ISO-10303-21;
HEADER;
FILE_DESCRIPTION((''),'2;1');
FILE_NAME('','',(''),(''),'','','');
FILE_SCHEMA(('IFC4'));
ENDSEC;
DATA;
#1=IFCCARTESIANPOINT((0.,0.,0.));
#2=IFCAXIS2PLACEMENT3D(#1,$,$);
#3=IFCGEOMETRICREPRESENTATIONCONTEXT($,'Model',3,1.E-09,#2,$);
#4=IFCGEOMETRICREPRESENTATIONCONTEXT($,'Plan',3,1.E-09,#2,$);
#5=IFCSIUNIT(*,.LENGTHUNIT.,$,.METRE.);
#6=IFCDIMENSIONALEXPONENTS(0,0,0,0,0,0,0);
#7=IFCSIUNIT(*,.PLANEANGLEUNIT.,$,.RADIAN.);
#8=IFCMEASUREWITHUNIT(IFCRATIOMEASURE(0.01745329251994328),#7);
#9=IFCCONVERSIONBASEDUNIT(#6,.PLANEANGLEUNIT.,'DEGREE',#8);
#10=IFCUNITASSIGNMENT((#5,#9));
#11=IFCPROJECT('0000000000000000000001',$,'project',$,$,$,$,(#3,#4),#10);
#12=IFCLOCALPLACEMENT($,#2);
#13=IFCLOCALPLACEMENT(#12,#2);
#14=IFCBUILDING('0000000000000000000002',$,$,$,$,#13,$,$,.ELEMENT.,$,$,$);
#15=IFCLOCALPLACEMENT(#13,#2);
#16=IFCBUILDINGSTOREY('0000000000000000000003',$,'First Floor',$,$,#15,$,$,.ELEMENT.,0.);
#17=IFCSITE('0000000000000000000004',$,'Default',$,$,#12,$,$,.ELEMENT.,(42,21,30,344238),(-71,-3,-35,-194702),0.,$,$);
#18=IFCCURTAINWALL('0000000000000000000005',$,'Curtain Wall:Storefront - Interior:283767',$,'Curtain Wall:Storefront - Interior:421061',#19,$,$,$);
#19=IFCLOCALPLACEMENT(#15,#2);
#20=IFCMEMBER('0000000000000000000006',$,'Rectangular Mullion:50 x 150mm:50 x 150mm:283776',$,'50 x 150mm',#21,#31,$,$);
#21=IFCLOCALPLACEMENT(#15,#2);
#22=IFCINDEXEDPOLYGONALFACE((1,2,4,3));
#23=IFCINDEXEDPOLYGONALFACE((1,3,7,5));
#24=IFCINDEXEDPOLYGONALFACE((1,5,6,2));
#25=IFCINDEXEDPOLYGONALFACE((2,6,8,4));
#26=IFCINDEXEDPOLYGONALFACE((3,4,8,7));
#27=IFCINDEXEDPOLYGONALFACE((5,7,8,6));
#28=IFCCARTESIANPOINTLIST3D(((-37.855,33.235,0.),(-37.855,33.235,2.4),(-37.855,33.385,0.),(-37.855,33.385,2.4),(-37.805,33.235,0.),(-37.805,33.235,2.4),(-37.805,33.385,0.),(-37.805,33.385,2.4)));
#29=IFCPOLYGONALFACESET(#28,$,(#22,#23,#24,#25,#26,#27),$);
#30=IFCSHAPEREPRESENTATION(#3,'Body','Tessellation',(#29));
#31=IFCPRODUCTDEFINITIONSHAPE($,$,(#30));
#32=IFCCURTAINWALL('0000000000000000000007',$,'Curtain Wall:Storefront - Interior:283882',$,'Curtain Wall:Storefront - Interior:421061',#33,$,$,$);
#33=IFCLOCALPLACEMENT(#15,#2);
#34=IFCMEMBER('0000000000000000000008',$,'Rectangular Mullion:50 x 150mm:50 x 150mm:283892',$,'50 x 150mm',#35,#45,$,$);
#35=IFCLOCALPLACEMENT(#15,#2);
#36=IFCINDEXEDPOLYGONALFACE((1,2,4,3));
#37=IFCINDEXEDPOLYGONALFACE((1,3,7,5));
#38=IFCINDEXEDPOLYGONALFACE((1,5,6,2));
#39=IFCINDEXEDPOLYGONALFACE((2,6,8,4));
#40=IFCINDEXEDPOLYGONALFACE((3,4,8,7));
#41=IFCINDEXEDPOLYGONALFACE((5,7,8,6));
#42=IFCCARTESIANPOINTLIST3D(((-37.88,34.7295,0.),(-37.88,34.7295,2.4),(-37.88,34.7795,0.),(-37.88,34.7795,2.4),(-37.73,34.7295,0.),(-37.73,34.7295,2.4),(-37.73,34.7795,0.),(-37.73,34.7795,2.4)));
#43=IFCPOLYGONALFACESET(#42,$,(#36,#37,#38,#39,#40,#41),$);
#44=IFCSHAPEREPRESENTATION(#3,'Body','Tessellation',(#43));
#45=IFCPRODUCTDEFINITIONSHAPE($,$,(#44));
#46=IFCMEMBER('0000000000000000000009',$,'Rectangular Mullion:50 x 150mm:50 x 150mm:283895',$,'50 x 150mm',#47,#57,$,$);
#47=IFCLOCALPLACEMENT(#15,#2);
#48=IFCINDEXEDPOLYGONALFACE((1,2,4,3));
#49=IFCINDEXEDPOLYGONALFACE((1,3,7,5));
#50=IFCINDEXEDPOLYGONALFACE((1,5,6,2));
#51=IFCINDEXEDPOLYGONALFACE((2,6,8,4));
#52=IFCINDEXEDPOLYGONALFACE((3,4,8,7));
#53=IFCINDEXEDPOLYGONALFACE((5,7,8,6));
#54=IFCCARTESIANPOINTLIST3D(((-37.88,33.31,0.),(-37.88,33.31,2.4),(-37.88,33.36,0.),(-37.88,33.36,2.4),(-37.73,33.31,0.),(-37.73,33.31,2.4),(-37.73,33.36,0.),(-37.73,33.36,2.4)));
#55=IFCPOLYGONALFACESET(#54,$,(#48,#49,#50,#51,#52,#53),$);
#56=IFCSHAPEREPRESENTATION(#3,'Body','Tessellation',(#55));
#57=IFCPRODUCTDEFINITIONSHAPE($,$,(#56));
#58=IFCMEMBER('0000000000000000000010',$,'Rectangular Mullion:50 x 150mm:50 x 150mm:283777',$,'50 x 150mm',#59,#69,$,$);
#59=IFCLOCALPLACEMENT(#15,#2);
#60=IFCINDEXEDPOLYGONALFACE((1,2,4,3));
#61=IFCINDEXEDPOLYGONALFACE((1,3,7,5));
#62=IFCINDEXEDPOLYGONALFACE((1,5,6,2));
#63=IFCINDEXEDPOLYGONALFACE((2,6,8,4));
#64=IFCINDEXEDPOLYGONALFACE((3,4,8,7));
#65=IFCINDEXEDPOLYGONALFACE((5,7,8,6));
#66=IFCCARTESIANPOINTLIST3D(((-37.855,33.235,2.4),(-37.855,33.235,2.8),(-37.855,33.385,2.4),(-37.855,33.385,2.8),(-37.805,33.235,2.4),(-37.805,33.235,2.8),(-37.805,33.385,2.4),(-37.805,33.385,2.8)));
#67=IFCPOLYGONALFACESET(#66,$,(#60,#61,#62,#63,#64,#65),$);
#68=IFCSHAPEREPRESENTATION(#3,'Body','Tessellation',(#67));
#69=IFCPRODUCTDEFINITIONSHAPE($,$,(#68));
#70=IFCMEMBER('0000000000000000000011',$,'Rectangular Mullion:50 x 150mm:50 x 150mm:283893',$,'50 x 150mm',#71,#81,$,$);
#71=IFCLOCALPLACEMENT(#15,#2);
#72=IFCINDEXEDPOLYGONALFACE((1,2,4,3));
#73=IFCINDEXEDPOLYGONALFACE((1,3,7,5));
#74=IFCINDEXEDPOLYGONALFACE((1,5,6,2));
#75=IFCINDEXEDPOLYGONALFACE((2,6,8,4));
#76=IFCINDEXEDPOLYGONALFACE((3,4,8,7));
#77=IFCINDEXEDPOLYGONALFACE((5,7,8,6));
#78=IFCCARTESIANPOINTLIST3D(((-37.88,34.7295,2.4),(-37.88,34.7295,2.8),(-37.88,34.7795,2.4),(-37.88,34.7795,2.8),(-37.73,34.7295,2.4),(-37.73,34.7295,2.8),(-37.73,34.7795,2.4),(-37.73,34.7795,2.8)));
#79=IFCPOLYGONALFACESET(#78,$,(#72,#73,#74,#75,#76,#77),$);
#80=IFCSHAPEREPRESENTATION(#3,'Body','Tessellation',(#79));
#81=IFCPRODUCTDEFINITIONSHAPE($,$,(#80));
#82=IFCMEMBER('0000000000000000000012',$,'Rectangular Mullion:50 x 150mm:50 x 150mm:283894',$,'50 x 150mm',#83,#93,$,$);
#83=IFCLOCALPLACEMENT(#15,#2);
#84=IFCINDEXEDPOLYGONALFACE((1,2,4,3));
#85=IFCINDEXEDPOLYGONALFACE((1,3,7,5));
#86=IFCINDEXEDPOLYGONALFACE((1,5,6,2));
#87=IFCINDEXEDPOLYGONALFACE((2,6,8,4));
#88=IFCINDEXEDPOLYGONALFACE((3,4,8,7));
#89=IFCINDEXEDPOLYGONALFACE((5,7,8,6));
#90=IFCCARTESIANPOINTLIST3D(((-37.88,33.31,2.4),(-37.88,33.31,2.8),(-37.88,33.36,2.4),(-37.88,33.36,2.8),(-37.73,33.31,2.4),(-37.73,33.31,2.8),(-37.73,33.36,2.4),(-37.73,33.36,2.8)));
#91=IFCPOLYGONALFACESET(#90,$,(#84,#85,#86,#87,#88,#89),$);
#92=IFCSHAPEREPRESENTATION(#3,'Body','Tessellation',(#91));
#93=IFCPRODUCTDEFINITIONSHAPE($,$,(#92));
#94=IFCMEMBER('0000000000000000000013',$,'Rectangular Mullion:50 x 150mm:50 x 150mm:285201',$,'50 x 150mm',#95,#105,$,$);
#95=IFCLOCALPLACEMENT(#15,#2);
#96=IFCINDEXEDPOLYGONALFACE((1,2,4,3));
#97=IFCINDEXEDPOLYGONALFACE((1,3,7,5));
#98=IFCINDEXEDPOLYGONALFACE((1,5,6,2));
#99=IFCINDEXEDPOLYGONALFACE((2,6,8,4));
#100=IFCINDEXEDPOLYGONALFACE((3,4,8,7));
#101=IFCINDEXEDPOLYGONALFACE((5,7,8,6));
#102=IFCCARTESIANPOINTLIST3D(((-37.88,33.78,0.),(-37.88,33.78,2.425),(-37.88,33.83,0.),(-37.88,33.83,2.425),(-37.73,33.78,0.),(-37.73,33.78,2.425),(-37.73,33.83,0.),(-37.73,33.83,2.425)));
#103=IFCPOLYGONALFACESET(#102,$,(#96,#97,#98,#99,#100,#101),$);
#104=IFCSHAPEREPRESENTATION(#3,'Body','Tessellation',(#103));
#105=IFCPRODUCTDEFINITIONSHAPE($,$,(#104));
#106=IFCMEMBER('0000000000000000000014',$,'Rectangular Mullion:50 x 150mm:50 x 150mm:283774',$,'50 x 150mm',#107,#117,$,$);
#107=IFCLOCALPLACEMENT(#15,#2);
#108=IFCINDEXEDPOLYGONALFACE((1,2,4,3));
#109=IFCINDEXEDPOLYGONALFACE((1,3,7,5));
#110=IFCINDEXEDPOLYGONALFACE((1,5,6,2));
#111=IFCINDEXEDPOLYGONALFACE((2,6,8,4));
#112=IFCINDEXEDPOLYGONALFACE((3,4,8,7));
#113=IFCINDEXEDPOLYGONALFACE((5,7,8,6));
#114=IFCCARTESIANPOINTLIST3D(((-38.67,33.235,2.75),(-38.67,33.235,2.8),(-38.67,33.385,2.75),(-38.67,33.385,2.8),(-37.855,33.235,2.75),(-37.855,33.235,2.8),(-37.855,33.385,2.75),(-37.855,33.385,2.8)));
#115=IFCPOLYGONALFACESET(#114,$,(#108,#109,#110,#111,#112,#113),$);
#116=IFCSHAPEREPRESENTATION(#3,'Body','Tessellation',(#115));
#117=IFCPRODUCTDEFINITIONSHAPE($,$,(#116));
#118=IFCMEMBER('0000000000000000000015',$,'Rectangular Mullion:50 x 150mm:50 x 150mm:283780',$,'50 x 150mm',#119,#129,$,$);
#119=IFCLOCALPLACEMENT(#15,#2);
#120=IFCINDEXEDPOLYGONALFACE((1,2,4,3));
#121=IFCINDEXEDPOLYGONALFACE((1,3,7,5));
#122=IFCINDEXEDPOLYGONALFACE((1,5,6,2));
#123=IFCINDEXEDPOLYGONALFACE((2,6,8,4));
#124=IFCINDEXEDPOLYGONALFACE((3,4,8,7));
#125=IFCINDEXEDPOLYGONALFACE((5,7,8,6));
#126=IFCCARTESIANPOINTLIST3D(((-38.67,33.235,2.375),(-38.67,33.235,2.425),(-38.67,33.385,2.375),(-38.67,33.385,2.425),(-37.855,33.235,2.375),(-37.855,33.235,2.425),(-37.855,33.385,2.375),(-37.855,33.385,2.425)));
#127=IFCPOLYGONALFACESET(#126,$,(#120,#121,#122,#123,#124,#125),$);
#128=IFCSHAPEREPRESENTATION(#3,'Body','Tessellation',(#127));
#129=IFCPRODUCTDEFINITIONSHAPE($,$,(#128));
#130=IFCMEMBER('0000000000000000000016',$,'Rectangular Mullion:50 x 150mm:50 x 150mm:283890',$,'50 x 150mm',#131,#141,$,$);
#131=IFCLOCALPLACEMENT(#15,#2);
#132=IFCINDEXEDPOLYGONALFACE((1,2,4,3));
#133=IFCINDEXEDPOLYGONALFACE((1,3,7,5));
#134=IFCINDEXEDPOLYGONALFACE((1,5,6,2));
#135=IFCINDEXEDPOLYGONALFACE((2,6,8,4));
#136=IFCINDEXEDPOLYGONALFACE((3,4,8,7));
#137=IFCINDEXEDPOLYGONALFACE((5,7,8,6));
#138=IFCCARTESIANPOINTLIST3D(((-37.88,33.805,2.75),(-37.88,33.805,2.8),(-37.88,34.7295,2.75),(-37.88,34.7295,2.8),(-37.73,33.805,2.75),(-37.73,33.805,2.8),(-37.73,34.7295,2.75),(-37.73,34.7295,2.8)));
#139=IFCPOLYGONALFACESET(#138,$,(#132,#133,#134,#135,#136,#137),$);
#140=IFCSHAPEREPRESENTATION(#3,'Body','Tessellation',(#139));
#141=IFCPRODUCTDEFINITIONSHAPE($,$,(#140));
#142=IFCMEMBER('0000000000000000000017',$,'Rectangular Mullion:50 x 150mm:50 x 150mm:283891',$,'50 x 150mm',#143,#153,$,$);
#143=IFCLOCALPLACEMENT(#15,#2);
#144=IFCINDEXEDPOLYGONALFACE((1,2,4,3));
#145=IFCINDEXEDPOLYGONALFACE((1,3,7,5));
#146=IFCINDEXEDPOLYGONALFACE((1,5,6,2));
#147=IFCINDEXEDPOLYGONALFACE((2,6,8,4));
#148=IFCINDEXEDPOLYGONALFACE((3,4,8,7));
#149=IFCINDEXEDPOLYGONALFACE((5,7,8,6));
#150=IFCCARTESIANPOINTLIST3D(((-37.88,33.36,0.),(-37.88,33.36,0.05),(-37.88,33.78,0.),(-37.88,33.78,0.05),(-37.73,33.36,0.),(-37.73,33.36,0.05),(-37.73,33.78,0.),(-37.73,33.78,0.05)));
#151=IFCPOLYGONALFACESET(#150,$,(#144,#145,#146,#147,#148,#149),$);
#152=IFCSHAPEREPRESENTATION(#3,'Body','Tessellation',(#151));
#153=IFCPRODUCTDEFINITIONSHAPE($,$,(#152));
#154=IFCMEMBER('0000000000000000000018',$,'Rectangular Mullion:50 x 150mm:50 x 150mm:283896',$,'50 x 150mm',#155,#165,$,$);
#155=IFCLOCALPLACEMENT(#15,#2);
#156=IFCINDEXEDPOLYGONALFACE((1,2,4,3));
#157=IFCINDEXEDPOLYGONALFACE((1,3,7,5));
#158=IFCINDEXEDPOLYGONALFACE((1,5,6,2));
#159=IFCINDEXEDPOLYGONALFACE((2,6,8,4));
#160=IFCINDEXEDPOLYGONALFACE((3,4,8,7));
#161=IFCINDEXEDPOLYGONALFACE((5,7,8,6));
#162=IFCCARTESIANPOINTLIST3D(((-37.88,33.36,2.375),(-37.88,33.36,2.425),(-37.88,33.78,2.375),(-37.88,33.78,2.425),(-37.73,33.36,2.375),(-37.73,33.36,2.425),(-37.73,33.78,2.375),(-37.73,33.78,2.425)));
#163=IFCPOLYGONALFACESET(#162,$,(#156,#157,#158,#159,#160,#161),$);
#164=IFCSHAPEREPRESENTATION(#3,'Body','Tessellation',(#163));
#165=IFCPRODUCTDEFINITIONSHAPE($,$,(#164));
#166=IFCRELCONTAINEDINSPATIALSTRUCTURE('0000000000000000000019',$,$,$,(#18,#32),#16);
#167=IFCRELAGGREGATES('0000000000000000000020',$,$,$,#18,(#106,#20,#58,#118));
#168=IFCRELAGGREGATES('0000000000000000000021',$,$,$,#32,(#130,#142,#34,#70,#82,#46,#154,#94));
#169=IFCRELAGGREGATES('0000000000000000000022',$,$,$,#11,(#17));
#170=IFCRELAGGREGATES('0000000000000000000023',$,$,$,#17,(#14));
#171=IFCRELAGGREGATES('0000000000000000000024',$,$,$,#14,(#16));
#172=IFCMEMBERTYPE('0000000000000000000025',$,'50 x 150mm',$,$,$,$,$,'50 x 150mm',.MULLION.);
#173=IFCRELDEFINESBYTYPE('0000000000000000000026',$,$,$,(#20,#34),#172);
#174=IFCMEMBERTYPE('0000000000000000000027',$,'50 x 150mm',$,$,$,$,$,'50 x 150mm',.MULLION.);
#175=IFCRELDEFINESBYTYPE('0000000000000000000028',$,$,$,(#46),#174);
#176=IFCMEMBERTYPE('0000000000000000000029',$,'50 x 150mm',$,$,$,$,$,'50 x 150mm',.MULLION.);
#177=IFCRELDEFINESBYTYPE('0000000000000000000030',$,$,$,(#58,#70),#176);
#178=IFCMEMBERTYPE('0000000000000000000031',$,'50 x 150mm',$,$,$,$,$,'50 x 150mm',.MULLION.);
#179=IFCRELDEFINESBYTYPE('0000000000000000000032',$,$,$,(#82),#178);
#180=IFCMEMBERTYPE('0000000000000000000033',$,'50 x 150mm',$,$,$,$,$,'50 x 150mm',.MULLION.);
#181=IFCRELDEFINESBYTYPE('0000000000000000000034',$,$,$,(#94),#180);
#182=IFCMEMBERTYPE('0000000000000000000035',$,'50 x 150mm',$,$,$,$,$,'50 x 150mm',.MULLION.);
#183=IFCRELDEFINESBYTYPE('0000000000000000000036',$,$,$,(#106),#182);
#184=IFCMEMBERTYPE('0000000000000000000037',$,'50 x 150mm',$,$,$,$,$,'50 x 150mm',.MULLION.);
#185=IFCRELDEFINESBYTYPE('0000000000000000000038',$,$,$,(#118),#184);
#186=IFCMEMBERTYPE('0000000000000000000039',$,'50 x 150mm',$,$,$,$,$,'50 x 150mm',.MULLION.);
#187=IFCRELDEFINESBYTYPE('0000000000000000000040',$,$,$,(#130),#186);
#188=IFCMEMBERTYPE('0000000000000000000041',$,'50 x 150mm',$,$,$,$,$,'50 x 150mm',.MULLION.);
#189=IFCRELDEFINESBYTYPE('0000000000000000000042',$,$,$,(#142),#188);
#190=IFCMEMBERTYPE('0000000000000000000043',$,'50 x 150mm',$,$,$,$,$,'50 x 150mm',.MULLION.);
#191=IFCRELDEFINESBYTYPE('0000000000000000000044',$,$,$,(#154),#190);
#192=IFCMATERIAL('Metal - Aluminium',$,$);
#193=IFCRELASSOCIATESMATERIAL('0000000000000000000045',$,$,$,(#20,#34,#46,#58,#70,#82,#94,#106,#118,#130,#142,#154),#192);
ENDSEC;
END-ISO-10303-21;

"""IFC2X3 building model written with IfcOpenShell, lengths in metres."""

from ifc_helpers import new_model, entity, si_unit, converted_unit, frame, origin, origin_2d_with_axis, place, context, project, spatial, rectangle, extrude, source, transform, mapped, material, type_object, type_shapes, element, aggregate, save


model = new_model("IFC2X3")

# Units and contexts
model_context = context("Model", 3, precision=1e-09, world=origin())
plan_context = context("Plan", 3, precision=1e-09, world=origin())
ifc_project = project(units=[si_unit("LENGTHUNIT", "METRE"), converted_unit("PLANEANGLEUNIT", "DEGREE", entity("IfcRatioMeasure", 0.01745329251994328), si_unit("PLANEANGLEUNIT", "RADIAN"), dimensions=[0, 0, 0, 0, 0, 0, 0])], contexts=[model_context, plan_context])

# Site, building, storey
site_placement = place(None, origin())
site = spatial("IfcSite", under=ifc_project, at=site_placement, Name="Default", CompositionType="ELEMENT", RefLatitude=(42, 21, 30, 344238), RefLongitude=(-71, -3, -35, -194702), RefElevation=0.0)
building_placement = place(site_placement, origin())
building = spatial("IfcBuilding", under=site, at=building_placement, CompositionType="ELEMENT")
storey_placement = place(building_placement, origin())
storey = spatial("IfcBuildingStorey", under=building, at=storey_placement, Name="First Floor", CompositionType="ELEMENT", Elevation=0.0)

# Curtain wall, member
curtain_wall_1_placement = place(storey_placement, origin())
curtain_wall_1 = element("IfcCurtainWall", 1, at=curtain_wall_1_placement, inside=storey, Name="Curtain Wall:Storefront - Interior:283767", ObjectType="Curtain Wall:Storefront - Interior:421061")
ifc_material_1 = material(Name="Metal - Aluminium")
member_type_1 = type_object("IfcMemberType", Name="50 x 150mm", ElementType="50 x 150mm", PredefinedType="MULLION")
shared_shape_1 = source(origin(), model_context, "Body", "SweptSolid", [
    extrude(rectangle(XDim=0.05, YDim=0.15, at=origin_2d_with_axis()), frame((-0.025, 0.0, -2.4), z_axis=(0.0, 0.0, 1.0), x_axis=(-1.0, 0.0, 0.0)), (0.0, 0.0, 1.0), 2.4),
])
type_shapes(member_type_1, [shared_shape_1])
member_1_placement = place(storey_placement, frame((-37.805, 33.31, 0.0), z_axis=(0.0, 0.0, -1.0), x_axis=(1.0, 0.0, 0.0)))
member_1 = element("IfcMember", 2, at=member_1_placement, type_object=member_type_1, material=ifc_material_1, Name="Rectangular Mullion:50 x 150mm:50 x 150mm:283776", ObjectType="50 x 150mm", context=model_context, shape_type="MappedRepresentation", body=[
    mapped(shared_shape_1, transform((0.0, 0.0, 0.0), scale=1.0)),
])

# Curtain wall, members
curtain_wall_2_placement = place(storey_placement, origin())
curtain_wall_2 = element("IfcCurtainWall", 3, at=curtain_wall_2_placement, inside=storey, Name="Curtain Wall:Storefront - Interior:283882", ObjectType="Curtain Wall:Storefront - Interior:421061")
member_2_placement = place(storey_placement, frame((-37.805, 34.7795, 0.0), z_axis=(0.0, 0.0, -1.0), x_axis=(0.0, 1.0, 0.0)))
member_2 = element("IfcMember", 4, at=member_2_placement, type_object=member_type_1, material=ifc_material_1, Name="Rectangular Mullion:50 x 150mm:50 x 150mm:283892", ObjectType="50 x 150mm", context=model_context, shape_type="MappedRepresentation", body=[
    mapped(shared_shape_1, transform((0.0, 0.0, 0.0), scale=1.0)),
])
member_type_2 = type_object("IfcMemberType", Name="50 x 150mm", ElementType="50 x 150mm", PredefinedType="MULLION")
shared_shape_2 = source(origin(), model_context, "Body", "SweptSolid", [
    extrude(rectangle(XDim=0.05, YDim=0.15, at=origin_2d_with_axis()), frame((-0.025, 0.0, -2.4), z_axis=(0.0, 0.0, 1.0), x_axis=(-1.0, 0.0, 0.0)), (0.0, 0.0, 1.0), 2.4),
])
type_shapes(member_type_2, [shared_shape_2])
member_3_placement = place(storey_placement, frame((-37.805, 33.31, 2.4), z_axis=(0.0, 0.0, 1.0), x_axis=(0.0, -1.0, 0.0)))
member_3 = element("IfcMember", 5, at=member_3_placement, type_object=member_type_2, material=ifc_material_1, Name="Rectangular Mullion:50 x 150mm:50 x 150mm:283895", ObjectType="50 x 150mm", context=model_context, shape_type="MappedRepresentation", body=[
    mapped(shared_shape_2, transform((0.0, 0.0, 0.0), scale=1.0)),
])

# Members
member_type_3 = type_object("IfcMemberType", Name="50 x 150mm", ElementType="50 x 150mm", PredefinedType="MULLION")
shared_shape_3 = source(origin(), model_context, "Body", "SweptSolid", [
    extrude(rectangle(XDim=0.05, YDim=0.15, at=origin_2d_with_axis()), frame((-0.025, 0.0, -0.4), z_axis=(0.0, 0.0, 1.0), x_axis=(-1.0, 0.0, 0.0)), (0.0, 0.0, 1.0), 0.4),
])
type_shapes(member_type_3, [shared_shape_3])
member_4_placement = place(storey_placement, frame((-37.805, 33.31, 2.4), z_axis=(0.0, 0.0, -1.0), x_axis=(1.0, 0.0, 0.0)))
member_4 = element("IfcMember", 6, at=member_4_placement, type_object=member_type_3, material=ifc_material_1, Name="Rectangular Mullion:50 x 150mm:50 x 150mm:283777", ObjectType="50 x 150mm", context=model_context, shape_type="MappedRepresentation", body=[
    mapped(shared_shape_3, transform((0.0, 0.0, 0.0), scale=1.0)),
])
member_5_placement = place(storey_placement, frame((-37.805, 34.7795, 2.4), z_axis=(0.0, 0.0, -1.0), x_axis=(0.0, 1.0, 0.0)))
member_5 = element("IfcMember", 7, at=member_5_placement, type_object=member_type_3, material=ifc_material_1, Name="Rectangular Mullion:50 x 150mm:50 x 150mm:283893", ObjectType="50 x 150mm", context=model_context, shape_type="MappedRepresentation", body=[
    mapped(shared_shape_3, transform((0.0, 0.0, 0.0), scale=1.0)),
])
member_type_4 = type_object("IfcMemberType", Name="50 x 150mm", ElementType="50 x 150mm", PredefinedType="MULLION")
shared_shape_4 = source(origin(), model_context, "Body", "SweptSolid", [
    extrude(rectangle(XDim=0.05, YDim=0.15, at=origin_2d_with_axis()), frame((-0.025, 0.0, -0.4), z_axis=(0.0, 0.0, 1.0), x_axis=(-1.0, 0.0, 0.0)), (0.0, 0.0, 1.0), 0.4),
])
type_shapes(member_type_4, [shared_shape_4])
member_6_placement = place(storey_placement, frame((-37.805, 33.31, 2.8), z_axis=(0.0, 0.0, 1.0), x_axis=(0.0, -1.0, 0.0)))
member_6 = element("IfcMember", 8, at=member_6_placement, type_object=member_type_4, material=ifc_material_1, Name="Rectangular Mullion:50 x 150mm:50 x 150mm:283894", ObjectType="50 x 150mm", context=model_context, shape_type="MappedRepresentation", body=[
    mapped(shared_shape_4, transform((0.0, 0.0, 0.0), scale=1.0)),
])
member_type_5 = type_object("IfcMemberType", Name="50 x 150mm", ElementType="50 x 150mm", PredefinedType="MULLION")
shared_shape_5 = source(origin(), model_context, "Body", "SweptSolid", [
    extrude(rectangle(XDim=0.05, YDim=0.15, at=origin_2d_with_axis()), frame((0.0, 0.0, -2.425), z_axis=(0.0, 0.0, 1.0), x_axis=(-1.0, 0.0, 0.0)), (0.0, 0.0, 1.0), 2.425),
])
type_shapes(member_type_5, [shared_shape_5])
member_7_placement = place(storey_placement, frame((-37.805, 33.805, 0.0), z_axis=(0.0, 0.0, -1.0), x_axis=(0.0, 1.0, 0.0)))
member_7 = element("IfcMember", 9, at=member_7_placement, type_object=member_type_5, material=ifc_material_1, Name="Rectangular Mullion:50 x 150mm:50 x 150mm:285201", ObjectType="50 x 150mm", context=model_context, shape_type="MappedRepresentation", body=[
    mapped(shared_shape_5, transform((0.0, 0.0, 0.0), scale=1.0)),
])
member_type_6 = type_object("IfcMemberType", Name="50 x 150mm", ElementType="50 x 150mm", PredefinedType="MULLION")
shared_shape_6 = source(origin(), model_context, "Body", "SweptSolid", [
    extrude(rectangle(XDim=0.05, YDim=0.15, at=origin_2d_with_axis()), frame((-0.025, 0.0, -0.815), z_axis=(0.0, 0.0, 1.0), x_axis=(-1.0, 0.0, 0.0)), (0.0, 0.0, 1.0), 0.815),
])
type_shapes(member_type_6, [shared_shape_6])
member_8_placement = place(storey_placement, frame((-37.855, 33.31, 2.8), z_axis=(1.0, 0.0, 0.0), x_axis=(0.0, 0.0, 1.0)))
member_8 = element("IfcMember", 10, at=member_8_placement, type_object=member_type_6, material=ifc_material_1, Name="Rectangular Mullion:50 x 150mm:50 x 150mm:283774", ObjectType="50 x 150mm", context=model_context, shape_type="MappedRepresentation", body=[
    mapped(shared_shape_6, transform((0.0, 0.0, 0.0), scale=1.0)),
])
member_type_7 = type_object("IfcMemberType", Name="50 x 150mm", ElementType="50 x 150mm", PredefinedType="MULLION")
shared_shape_7 = source(origin(), model_context, "Body", "SweptSolid", [
    extrude(rectangle(XDim=0.05, YDim=0.15, at=origin_2d_with_axis()), frame((0.0, 0.0, -0.815), z_axis=(0.0, 0.0, 1.0), x_axis=(-1.0, 0.0, 0.0)), (0.0, 0.0, 1.0), 0.815),
])
type_shapes(member_type_7, [shared_shape_7])
member_9_placement = place(storey_placement, frame((-37.855, 33.31, 2.4), z_axis=(1.0, 0.0, 0.0), x_axis=(0.0, 0.0, 1.0)))
member_9 = element("IfcMember", 11, at=member_9_placement, type_object=member_type_7, material=ifc_material_1, Name="Rectangular Mullion:50 x 150mm:50 x 150mm:283780", ObjectType="50 x 150mm", context=model_context, shape_type="MappedRepresentation", body=[
    mapped(shared_shape_7, transform((0.0, 0.0, 0.0), scale=1.0)),
])
member_type_8 = type_object("IfcMemberType", Name="50 x 150mm", ElementType="50 x 150mm", PredefinedType="MULLION")
shared_shape_8 = source(origin(), model_context, "Body", "SweptSolid", [
    extrude(rectangle(XDim=0.05, YDim=0.15, at=origin_2d_with_axis()), frame((-0.025, 0.0, -0.9245), z_axis=(0.0, 0.0, 1.0), x_axis=(-1.0, 0.0, 0.0)), (0.0, 0.0, 1.0), 0.9245),
])
type_shapes(member_type_8, [shared_shape_8])
member_10_placement = place(storey_placement, frame((-37.805, 34.7295, 2.8), z_axis=(0.0, 1.0, 0.0), x_axis=(0.0, 0.0, 1.0)))
member_10 = element("IfcMember", 12, at=member_10_placement, type_object=member_type_8, material=ifc_material_1, Name="Rectangular Mullion:50 x 150mm:50 x 150mm:283890", ObjectType="50 x 150mm", context=model_context, shape_type="MappedRepresentation", body=[
    mapped(shared_shape_8, transform((0.0, 0.0, 0.0), scale=1.0)),
])
member_type_9 = type_object("IfcMemberType", Name="50 x 150mm", ElementType="50 x 150mm", PredefinedType="MULLION")
shared_shape_9 = source(origin(), model_context, "Body", "SweptSolid", [
    extrude(rectangle(XDim=0.05, YDim=0.15, at=origin_2d_with_axis()), frame((-0.025, 0.0, -0.42), z_axis=(0.0, 0.0, 1.0), x_axis=(-1.0, 0.0, 0.0)), (0.0, 0.0, 1.0), 0.42),
])
type_shapes(member_type_9, [shared_shape_9])
member_11_placement = place(storey_placement, frame((-37.805, 33.36, 0.0), z_axis=(0.0, -1.0, 0.0), x_axis=(0.0, 0.0, -1.0)))
member_11 = element("IfcMember", 13, at=member_11_placement, type_object=member_type_9, material=ifc_material_1, Name="Rectangular Mullion:50 x 150mm:50 x 150mm:283891", ObjectType="50 x 150mm", context=model_context, shape_type="MappedRepresentation", body=[
    mapped(shared_shape_9, transform((0.0, 0.0, 0.0), scale=1.0)),
])
member_type_10 = type_object("IfcMemberType", Name="50 x 150mm", ElementType="50 x 150mm", PredefinedType="MULLION")
shared_shape_10 = source(origin(), model_context, "Body", "SweptSolid", [
    extrude(rectangle(XDim=0.05, YDim=0.15, at=origin_2d_with_axis()), frame((0.0, 0.0, -0.42), z_axis=(0.0, 0.0, 1.0), x_axis=(-1.0, 0.0, 0.0)), (0.0, 0.0, 1.0), 0.42),
])
type_shapes(member_type_10, [shared_shape_10])
member_12_placement = place(storey_placement, frame((-37.805, 33.78, 2.4), z_axis=(0.0, 1.0, 0.0), x_axis=(0.0, 0.0, 1.0)))
member_12 = element("IfcMember", 14, at=member_12_placement, type_object=member_type_10, material=ifc_material_1, Name="Rectangular Mullion:50 x 150mm:50 x 150mm:283896", ObjectType="50 x 150mm", context=model_context, shape_type="MappedRepresentation", body=[
    mapped(shared_shape_10, transform((0.0, 0.0, 0.0), scale=1.0)),
])

aggregate(curtain_wall_1, [member_8, member_1, member_4, member_9])

aggregate(curtain_wall_2, [member_10, member_11, member_2, member_5, member_6, member_3, member_12, member_7])

save(model, "model.ifc")
